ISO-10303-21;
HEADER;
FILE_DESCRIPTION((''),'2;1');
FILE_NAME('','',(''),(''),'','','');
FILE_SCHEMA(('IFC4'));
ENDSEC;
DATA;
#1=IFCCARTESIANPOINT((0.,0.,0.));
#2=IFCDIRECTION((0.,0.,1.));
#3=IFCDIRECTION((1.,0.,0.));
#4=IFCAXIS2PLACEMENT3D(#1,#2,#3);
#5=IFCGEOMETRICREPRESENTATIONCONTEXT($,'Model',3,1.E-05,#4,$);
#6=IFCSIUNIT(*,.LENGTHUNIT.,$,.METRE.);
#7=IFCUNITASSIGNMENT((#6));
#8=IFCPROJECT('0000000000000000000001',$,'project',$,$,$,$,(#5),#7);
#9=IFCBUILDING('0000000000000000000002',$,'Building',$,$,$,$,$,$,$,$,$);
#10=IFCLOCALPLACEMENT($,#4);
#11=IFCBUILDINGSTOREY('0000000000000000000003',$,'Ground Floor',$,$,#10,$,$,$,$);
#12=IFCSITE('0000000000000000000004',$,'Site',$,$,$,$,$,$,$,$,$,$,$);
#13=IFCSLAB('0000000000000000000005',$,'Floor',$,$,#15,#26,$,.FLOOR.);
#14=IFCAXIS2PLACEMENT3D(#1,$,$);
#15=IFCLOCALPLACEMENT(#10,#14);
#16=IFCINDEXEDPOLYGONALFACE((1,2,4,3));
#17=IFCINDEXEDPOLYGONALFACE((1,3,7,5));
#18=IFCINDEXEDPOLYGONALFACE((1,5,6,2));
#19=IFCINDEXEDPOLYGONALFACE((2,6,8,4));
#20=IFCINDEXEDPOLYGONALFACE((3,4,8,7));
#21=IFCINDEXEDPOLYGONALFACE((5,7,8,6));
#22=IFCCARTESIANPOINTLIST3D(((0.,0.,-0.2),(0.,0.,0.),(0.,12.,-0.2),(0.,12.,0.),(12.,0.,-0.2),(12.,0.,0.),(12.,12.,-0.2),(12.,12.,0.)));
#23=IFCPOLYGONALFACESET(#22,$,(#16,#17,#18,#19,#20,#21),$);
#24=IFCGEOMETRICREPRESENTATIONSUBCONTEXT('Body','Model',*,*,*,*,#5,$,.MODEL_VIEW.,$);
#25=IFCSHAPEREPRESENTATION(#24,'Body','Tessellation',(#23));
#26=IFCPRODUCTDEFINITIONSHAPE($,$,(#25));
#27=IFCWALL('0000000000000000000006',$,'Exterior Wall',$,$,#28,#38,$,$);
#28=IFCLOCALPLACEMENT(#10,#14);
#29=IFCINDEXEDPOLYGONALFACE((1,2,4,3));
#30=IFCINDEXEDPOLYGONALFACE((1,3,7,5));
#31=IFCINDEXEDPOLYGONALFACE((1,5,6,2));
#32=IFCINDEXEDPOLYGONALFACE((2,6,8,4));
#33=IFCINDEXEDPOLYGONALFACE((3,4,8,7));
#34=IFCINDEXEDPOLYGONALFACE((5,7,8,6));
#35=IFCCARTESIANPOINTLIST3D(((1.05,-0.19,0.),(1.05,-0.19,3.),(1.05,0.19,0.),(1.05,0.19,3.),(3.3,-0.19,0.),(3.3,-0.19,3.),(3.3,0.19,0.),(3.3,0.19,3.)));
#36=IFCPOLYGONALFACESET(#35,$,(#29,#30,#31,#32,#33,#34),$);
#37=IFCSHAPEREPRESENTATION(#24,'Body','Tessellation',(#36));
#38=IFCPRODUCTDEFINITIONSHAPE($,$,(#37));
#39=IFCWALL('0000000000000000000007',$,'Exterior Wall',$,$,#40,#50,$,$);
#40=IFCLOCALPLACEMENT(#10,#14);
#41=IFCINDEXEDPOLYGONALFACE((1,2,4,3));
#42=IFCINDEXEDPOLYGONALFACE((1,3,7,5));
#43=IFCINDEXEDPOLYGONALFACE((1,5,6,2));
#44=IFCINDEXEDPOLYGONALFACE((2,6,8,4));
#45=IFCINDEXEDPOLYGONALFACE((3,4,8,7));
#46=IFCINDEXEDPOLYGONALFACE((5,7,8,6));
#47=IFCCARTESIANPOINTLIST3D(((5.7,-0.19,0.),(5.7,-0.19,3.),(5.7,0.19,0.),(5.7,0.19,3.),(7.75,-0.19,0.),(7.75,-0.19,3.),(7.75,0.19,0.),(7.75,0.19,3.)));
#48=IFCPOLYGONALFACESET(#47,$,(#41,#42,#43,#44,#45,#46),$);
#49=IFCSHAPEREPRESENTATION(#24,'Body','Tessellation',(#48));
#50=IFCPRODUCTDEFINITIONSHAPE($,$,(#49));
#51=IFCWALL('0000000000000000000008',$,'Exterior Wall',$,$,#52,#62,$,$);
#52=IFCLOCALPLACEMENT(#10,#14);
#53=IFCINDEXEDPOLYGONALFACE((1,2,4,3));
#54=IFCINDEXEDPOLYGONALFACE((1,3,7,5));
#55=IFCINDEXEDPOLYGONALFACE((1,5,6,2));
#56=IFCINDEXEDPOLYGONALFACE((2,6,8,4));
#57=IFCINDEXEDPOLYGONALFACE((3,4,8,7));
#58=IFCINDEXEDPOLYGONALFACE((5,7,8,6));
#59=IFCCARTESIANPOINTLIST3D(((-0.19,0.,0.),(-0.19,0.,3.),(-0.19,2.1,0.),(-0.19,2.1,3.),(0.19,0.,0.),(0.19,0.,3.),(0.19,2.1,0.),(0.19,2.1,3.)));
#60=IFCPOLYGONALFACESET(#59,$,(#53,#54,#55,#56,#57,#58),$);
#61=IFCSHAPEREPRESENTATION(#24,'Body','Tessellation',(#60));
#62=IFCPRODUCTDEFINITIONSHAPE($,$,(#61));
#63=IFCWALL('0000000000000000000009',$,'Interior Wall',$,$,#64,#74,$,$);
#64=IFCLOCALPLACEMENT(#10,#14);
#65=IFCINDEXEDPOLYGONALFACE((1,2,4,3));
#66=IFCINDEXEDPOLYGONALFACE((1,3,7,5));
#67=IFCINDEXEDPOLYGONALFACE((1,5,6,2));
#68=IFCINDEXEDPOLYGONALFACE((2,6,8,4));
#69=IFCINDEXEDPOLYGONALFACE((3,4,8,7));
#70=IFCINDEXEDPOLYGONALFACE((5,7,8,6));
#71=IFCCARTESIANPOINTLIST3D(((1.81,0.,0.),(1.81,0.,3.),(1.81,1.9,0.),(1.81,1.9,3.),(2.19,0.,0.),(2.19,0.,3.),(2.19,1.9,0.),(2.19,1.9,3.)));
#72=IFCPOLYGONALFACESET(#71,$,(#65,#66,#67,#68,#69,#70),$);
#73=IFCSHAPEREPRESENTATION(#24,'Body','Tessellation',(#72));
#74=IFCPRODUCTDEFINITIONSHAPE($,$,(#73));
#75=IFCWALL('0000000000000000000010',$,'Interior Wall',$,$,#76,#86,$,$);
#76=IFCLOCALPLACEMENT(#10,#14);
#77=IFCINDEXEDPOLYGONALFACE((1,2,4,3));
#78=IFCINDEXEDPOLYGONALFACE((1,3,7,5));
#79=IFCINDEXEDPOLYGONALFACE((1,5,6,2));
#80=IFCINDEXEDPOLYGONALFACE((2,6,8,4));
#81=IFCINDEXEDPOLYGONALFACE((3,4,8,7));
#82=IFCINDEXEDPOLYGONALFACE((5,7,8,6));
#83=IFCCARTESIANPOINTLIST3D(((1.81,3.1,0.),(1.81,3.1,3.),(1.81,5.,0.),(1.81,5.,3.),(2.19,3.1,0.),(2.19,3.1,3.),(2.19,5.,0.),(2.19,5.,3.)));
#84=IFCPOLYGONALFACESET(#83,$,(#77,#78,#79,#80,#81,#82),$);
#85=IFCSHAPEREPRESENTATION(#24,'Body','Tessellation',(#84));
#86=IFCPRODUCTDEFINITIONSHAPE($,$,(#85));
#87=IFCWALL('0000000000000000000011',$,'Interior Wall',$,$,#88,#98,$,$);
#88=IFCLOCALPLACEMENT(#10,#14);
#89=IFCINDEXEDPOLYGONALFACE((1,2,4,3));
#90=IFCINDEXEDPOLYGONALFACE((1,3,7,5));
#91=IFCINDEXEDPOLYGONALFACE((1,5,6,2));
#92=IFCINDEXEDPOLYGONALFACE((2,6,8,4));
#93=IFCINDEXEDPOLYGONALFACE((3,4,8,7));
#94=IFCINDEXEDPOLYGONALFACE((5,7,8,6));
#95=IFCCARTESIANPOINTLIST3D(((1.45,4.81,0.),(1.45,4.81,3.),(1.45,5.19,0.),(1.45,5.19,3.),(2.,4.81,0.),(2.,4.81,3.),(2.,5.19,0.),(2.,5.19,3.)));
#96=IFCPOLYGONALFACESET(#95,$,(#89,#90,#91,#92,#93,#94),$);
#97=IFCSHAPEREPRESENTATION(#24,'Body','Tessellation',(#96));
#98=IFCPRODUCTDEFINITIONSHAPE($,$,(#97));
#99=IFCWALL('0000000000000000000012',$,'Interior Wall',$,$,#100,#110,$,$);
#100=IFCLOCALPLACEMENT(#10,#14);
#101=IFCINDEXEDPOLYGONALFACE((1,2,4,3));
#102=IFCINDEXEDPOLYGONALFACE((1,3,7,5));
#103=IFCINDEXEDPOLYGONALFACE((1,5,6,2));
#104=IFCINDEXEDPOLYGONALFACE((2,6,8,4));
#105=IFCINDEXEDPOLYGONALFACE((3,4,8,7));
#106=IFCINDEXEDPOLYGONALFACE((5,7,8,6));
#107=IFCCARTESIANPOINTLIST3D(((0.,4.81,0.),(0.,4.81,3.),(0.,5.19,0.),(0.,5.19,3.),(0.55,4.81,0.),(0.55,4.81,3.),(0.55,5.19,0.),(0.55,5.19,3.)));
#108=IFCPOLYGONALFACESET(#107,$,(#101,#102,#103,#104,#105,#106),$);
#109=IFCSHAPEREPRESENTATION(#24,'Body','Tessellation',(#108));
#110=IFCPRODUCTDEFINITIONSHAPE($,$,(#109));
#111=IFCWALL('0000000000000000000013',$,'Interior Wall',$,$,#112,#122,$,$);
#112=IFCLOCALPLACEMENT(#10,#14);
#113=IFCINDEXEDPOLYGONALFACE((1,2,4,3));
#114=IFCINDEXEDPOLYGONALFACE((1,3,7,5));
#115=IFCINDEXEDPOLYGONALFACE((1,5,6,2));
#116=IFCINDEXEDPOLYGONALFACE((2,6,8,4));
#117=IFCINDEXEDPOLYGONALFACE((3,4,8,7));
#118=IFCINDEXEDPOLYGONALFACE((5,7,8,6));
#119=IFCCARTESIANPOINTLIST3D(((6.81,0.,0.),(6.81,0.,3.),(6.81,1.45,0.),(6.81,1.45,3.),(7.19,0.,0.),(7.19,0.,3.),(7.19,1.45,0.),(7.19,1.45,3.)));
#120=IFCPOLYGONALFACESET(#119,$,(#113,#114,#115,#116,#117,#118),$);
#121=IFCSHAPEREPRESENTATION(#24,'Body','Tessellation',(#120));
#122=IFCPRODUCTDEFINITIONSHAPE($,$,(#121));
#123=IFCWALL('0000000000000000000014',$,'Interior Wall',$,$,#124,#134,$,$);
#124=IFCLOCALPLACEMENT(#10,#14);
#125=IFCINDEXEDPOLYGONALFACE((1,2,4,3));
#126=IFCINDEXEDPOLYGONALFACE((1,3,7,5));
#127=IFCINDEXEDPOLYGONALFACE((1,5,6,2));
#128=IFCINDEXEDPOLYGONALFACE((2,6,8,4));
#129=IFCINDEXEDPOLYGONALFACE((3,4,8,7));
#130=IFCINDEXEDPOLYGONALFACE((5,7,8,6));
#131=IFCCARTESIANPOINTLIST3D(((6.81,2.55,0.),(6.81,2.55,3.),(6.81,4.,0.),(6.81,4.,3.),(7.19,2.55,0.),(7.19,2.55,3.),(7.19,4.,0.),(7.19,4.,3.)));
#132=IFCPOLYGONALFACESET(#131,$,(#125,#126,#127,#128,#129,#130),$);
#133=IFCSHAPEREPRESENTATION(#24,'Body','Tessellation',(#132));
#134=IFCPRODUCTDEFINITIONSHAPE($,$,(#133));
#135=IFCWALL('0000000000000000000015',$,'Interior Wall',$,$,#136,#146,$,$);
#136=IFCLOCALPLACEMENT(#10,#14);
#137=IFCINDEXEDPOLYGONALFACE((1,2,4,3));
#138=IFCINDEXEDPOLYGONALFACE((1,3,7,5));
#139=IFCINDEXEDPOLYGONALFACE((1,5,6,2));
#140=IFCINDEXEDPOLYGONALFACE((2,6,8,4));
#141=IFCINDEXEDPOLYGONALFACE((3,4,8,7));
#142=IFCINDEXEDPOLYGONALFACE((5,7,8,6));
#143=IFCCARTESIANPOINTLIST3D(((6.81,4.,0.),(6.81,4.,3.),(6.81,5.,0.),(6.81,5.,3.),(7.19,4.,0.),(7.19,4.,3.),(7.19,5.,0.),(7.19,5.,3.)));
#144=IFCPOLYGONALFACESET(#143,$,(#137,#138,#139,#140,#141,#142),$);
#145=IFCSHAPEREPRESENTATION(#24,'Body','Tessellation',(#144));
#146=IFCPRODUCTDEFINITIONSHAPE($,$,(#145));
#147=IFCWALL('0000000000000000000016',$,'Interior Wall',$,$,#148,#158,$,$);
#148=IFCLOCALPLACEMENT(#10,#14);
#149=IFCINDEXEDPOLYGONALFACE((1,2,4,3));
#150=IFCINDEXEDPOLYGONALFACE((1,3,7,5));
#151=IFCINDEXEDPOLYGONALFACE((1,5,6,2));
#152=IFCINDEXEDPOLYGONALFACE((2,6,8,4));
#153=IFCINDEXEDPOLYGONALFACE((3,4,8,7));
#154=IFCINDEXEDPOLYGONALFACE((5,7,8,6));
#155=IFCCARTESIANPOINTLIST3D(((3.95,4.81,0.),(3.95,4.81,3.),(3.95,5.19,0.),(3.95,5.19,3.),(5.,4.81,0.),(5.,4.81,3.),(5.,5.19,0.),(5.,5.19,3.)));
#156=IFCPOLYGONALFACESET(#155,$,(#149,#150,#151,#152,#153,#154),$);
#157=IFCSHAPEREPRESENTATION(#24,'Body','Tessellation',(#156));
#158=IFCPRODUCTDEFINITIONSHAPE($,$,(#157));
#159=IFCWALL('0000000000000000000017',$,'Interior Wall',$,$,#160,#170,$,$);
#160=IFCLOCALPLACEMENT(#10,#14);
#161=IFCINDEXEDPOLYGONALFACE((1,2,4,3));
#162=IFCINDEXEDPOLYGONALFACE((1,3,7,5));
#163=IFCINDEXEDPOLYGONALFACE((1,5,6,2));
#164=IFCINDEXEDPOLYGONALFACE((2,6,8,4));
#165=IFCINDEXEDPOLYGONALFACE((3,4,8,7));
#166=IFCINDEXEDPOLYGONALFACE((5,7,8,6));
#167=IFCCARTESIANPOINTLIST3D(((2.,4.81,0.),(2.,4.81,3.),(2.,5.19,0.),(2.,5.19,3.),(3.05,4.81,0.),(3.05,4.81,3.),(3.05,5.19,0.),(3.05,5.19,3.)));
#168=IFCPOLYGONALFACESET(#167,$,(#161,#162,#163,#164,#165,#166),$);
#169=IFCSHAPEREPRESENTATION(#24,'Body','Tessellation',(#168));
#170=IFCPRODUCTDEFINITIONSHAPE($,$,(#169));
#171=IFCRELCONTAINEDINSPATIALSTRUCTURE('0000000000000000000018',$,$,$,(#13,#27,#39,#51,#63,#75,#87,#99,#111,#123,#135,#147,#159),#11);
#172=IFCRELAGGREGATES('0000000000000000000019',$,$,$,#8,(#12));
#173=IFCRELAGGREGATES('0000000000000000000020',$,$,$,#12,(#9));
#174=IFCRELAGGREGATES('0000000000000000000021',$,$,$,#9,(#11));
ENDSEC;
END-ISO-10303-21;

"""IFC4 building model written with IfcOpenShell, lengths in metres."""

from ifc_helpers import new_model, si_unit, frame, origin_with_axes, place, context, subcontext, project, spatial, indexed_curve, outline, extrude, element, save


model = new_model("IFC4")

# Units and contexts
model_context = context("Model", 3, precision=1e-05, world=origin_with_axes())
body_context = subcontext(model_context, "Body", "Model", "MODEL_VIEW")
ifc_project = project(units=[si_unit("LENGTHUNIT", "METRE")], contexts=[model_context])

# Site, building, storey
site = spatial("IfcSite", under=ifc_project, Name="Site")
building = spatial("IfcBuilding", under=site, Name="Building")
storey_placement = place(None, origin_with_axes())
storey = spatial("IfcBuildingStorey", under=building, at=storey_placement, Name="Ground Floor")

# Slab
slab_placement = place(storey_placement, frame((0.0, 0.0, -0.2), z_axis=(0.0, 0.0, 1.0), x_axis=(1.0, 0.0, 0.0)))
element("IfcSlab", 1, at=slab_placement, inside=storey, Name="Floor", PredefinedType="FLOOR", context=body_context, shape_type="SweptSolid", body=[
    extrude(outline(indexed_curve([(0.0, 0.0), (12.0, 0.0), (12.0, 12.0), (0.0, 12.0)])), None, (0.0, 0.0, 1.0), 0.2),
])

# Walls
wall_1_placement = place(storey_placement, frame((1.05, 0.0, 0.0), z_axis=(0.0, 0.0, 1.0), x_axis=(1.0, 0.0, 0.0)))
element("IfcWall", 2, at=wall_1_placement, inside=storey, Name="Exterior Wall", context=body_context, shape_type="SweptSolid", body=[
    extrude(outline(indexed_curve([(0.0, 0.0), (0.0, 0.38), (2.25, 0.38), (2.25, 0.0), (0.0, 0.0)], self_intersect=False)), frame((0.0, -0.19, 0.0), z_axis=(0.0, 0.0, 1.0), x_axis=(1.0, 0.0, 0.0)), (0.0, 0.0, 1.0), 3.0),
])
wall_2_placement = place(storey_placement, frame((5.7, 0.0, 0.0), z_axis=(0.0, 0.0, 1.0), x_axis=(1.0, 0.0, 0.0)))
element("IfcWall", 3, at=wall_2_placement, inside=storey, Name="Exterior Wall", context=body_context, shape_type="SweptSolid", body=[
    extrude(outline(indexed_curve([(0.0, 0.0), (0.0, 0.38), (2.05, 0.38), (2.05, 0.0), (0.0, 0.0)], self_intersect=False)), frame((0.0, -0.19, 0.0), z_axis=(0.0, 0.0, 1.0), x_axis=(1.0, 0.0, 0.0)), (0.0, 0.0, 1.0), 3.0),
])
wall_3_placement = place(storey_placement, frame((0.0, 2.1, 0.0), z_axis=(0.0, 0.0, 1.0), x_axis=(0.0, -1.0, 0.0)))
element("IfcWall", 4, at=wall_3_placement, inside=storey, Name="Exterior Wall", context=body_context, shape_type="SweptSolid", body=[
    extrude(outline(indexed_curve([(0.0, 0.0), (0.0, 0.38), (2.1, 0.38), (2.1, 0.0), (0.0, 0.0)], self_intersect=False)), frame((0.0, -0.19, 0.0), z_axis=(0.0, 0.0, 1.0), x_axis=(1.0, 0.0, 0.0)), (0.0, 0.0, 1.0), 3.0),
])
for number, where, z_axis, x_axis, name in (
    (5, (2.0, 0.0, 0.0), (0.0, 0.0, 1.0), (0.0, 1.0, 0.0), "Interior Wall"),
    (6, (2.0, 3.1, 0.0), (0.0, 0.0, 1.0), (0.0, 1.0, 0.0), "Interior Wall"),
):
    element("IfcWall", number, at=place(storey_placement, frame(where, z_axis=z_axis, x_axis=x_axis)), inside=storey, Name=name, context=body_context, shape_type="SweptSolid", body=[
        extrude(outline(indexed_curve([(0.0, 0.0), (0.0, 0.38), (1.9, 0.38), (1.9, 0.0), (0.0, 0.0)], self_intersect=False)), frame((0.0, -0.19, 0.0), z_axis=(0.0, 0.0, 1.0), x_axis=(1.0, 0.0, 0.0)), (0.0, 0.0, 1.0), 3.0),
    ])
for number, where, z_axis, x_axis, name in (
    (7, (2.0, 5.0, 0.0), (0.0, 0.0, 1.0), (-1.0, 0.0, 0.0), "Interior Wall"),
    (8, (0.55, 5.0, 0.0), (0.0, 0.0, 1.0), (-1.0, 0.0, 0.0), "Interior Wall"),
):
    element("IfcWall", number, at=place(storey_placement, frame(where, z_axis=z_axis, x_axis=x_axis)), inside=storey, Name=name, context=body_context, shape_type="SweptSolid", body=[
        extrude(outline(indexed_curve([(0.0, 0.0), (0.0, 0.38), (0.55, 0.38), (0.55, 0.0), (0.0, 0.0)], self_intersect=False)), frame((0.0, -0.19, 0.0), z_axis=(0.0, 0.0, 1.0), x_axis=(1.0, 0.0, 0.0)), (0.0, 0.0, 1.0), 3.0),
    ])
wall_4_placement = place(storey_placement, frame((7.0, 0.0, 0.0), z_axis=(0.0, 0.0, 1.0), x_axis=(0.0, 1.0, 0.0)))
element("IfcWall", 9, at=wall_4_placement, inside=storey, Name="Interior Wall", context=body_context, shape_type="SweptSolid", body=[
    extrude(outline(indexed_curve([(0.0, 0.0), (0.0, 0.38), (1.45, 0.38), (1.45, 0.0), (0.0, 0.0)], self_intersect=False)), frame((0.0, -0.19, 0.0), z_axis=(0.0, 0.0, 1.0), x_axis=(1.0, 0.0, 0.0)), (0.0, 0.0, 1.0), 3.0),
])
wall_5_placement = place(storey_placement, frame((7.0, 2.55, 0.0), z_axis=(0.0, 0.0, 1.0), x_axis=(0.0, 1.0, 0.0)))
element("IfcWall", 10, at=wall_5_placement, inside=storey, Name="Interior Wall", context=body_context, shape_type="SweptSolid", body=[
    extrude(outline(indexed_curve([(0.0, 0.0), (0.0, 0.38), (1.45, 0.38), (1.45, 0.0), (0.0, 0.0)], self_intersect=False)), frame((0.0, -0.19, 0.0), z_axis=(0.0, 0.0, 1.0), x_axis=(1.0, 0.0, 0.0)), (0.0, 0.0, 1.0), 3.0),
])
wall_6_placement = place(storey_placement, frame((7.0, 4.0, 0.0), z_axis=(0.0, 0.0, 1.0), x_axis=(0.0, 1.0, 0.0)))
element("IfcWall", 11, at=wall_6_placement, inside=storey, Name="Interior Wall", context=body_context, shape_type="SweptSolid", body=[
    extrude(outline(indexed_curve([(0.0, 0.0), (0.0, 0.38), (1.0, 0.38), (1.0, 0.0), (0.0, 0.0)], self_intersect=False)), frame((0.0, -0.19, 0.0), z_axis=(0.0, 0.0, 1.0), x_axis=(1.0, 0.0, 0.0)), (0.0, 0.0, 1.0), 3.0),
])
for number, where, z_axis, x_axis, name in (
    (12, (5.0, 5.0, 0.0), (0.0, 0.0, 1.0), (-1.0, 0.0, 0.0), "Interior Wall"),
    (13, (3.05, 5.0, 0.0), (0.0, 0.0, 1.0), (-1.0, 0.0, 0.0), "Interior Wall"),
):
    element("IfcWall", number, at=place(storey_placement, frame(where, z_axis=z_axis, x_axis=x_axis)), inside=storey, Name=name, context=body_context, shape_type="SweptSolid", body=[
        extrude(outline(indexed_curve([(0.0, 0.0), (0.0, 0.38), (1.05, 0.38), (1.05, 0.0), (0.0, 0.0)], self_intersect=False)), frame((0.0, -0.19, 0.0), z_axis=(0.0, 0.0, 1.0), x_axis=(1.0, 0.0, 0.0)), (0.0, 0.0, 1.0), 3.0),
    ])

save(model, "model.ifc")
